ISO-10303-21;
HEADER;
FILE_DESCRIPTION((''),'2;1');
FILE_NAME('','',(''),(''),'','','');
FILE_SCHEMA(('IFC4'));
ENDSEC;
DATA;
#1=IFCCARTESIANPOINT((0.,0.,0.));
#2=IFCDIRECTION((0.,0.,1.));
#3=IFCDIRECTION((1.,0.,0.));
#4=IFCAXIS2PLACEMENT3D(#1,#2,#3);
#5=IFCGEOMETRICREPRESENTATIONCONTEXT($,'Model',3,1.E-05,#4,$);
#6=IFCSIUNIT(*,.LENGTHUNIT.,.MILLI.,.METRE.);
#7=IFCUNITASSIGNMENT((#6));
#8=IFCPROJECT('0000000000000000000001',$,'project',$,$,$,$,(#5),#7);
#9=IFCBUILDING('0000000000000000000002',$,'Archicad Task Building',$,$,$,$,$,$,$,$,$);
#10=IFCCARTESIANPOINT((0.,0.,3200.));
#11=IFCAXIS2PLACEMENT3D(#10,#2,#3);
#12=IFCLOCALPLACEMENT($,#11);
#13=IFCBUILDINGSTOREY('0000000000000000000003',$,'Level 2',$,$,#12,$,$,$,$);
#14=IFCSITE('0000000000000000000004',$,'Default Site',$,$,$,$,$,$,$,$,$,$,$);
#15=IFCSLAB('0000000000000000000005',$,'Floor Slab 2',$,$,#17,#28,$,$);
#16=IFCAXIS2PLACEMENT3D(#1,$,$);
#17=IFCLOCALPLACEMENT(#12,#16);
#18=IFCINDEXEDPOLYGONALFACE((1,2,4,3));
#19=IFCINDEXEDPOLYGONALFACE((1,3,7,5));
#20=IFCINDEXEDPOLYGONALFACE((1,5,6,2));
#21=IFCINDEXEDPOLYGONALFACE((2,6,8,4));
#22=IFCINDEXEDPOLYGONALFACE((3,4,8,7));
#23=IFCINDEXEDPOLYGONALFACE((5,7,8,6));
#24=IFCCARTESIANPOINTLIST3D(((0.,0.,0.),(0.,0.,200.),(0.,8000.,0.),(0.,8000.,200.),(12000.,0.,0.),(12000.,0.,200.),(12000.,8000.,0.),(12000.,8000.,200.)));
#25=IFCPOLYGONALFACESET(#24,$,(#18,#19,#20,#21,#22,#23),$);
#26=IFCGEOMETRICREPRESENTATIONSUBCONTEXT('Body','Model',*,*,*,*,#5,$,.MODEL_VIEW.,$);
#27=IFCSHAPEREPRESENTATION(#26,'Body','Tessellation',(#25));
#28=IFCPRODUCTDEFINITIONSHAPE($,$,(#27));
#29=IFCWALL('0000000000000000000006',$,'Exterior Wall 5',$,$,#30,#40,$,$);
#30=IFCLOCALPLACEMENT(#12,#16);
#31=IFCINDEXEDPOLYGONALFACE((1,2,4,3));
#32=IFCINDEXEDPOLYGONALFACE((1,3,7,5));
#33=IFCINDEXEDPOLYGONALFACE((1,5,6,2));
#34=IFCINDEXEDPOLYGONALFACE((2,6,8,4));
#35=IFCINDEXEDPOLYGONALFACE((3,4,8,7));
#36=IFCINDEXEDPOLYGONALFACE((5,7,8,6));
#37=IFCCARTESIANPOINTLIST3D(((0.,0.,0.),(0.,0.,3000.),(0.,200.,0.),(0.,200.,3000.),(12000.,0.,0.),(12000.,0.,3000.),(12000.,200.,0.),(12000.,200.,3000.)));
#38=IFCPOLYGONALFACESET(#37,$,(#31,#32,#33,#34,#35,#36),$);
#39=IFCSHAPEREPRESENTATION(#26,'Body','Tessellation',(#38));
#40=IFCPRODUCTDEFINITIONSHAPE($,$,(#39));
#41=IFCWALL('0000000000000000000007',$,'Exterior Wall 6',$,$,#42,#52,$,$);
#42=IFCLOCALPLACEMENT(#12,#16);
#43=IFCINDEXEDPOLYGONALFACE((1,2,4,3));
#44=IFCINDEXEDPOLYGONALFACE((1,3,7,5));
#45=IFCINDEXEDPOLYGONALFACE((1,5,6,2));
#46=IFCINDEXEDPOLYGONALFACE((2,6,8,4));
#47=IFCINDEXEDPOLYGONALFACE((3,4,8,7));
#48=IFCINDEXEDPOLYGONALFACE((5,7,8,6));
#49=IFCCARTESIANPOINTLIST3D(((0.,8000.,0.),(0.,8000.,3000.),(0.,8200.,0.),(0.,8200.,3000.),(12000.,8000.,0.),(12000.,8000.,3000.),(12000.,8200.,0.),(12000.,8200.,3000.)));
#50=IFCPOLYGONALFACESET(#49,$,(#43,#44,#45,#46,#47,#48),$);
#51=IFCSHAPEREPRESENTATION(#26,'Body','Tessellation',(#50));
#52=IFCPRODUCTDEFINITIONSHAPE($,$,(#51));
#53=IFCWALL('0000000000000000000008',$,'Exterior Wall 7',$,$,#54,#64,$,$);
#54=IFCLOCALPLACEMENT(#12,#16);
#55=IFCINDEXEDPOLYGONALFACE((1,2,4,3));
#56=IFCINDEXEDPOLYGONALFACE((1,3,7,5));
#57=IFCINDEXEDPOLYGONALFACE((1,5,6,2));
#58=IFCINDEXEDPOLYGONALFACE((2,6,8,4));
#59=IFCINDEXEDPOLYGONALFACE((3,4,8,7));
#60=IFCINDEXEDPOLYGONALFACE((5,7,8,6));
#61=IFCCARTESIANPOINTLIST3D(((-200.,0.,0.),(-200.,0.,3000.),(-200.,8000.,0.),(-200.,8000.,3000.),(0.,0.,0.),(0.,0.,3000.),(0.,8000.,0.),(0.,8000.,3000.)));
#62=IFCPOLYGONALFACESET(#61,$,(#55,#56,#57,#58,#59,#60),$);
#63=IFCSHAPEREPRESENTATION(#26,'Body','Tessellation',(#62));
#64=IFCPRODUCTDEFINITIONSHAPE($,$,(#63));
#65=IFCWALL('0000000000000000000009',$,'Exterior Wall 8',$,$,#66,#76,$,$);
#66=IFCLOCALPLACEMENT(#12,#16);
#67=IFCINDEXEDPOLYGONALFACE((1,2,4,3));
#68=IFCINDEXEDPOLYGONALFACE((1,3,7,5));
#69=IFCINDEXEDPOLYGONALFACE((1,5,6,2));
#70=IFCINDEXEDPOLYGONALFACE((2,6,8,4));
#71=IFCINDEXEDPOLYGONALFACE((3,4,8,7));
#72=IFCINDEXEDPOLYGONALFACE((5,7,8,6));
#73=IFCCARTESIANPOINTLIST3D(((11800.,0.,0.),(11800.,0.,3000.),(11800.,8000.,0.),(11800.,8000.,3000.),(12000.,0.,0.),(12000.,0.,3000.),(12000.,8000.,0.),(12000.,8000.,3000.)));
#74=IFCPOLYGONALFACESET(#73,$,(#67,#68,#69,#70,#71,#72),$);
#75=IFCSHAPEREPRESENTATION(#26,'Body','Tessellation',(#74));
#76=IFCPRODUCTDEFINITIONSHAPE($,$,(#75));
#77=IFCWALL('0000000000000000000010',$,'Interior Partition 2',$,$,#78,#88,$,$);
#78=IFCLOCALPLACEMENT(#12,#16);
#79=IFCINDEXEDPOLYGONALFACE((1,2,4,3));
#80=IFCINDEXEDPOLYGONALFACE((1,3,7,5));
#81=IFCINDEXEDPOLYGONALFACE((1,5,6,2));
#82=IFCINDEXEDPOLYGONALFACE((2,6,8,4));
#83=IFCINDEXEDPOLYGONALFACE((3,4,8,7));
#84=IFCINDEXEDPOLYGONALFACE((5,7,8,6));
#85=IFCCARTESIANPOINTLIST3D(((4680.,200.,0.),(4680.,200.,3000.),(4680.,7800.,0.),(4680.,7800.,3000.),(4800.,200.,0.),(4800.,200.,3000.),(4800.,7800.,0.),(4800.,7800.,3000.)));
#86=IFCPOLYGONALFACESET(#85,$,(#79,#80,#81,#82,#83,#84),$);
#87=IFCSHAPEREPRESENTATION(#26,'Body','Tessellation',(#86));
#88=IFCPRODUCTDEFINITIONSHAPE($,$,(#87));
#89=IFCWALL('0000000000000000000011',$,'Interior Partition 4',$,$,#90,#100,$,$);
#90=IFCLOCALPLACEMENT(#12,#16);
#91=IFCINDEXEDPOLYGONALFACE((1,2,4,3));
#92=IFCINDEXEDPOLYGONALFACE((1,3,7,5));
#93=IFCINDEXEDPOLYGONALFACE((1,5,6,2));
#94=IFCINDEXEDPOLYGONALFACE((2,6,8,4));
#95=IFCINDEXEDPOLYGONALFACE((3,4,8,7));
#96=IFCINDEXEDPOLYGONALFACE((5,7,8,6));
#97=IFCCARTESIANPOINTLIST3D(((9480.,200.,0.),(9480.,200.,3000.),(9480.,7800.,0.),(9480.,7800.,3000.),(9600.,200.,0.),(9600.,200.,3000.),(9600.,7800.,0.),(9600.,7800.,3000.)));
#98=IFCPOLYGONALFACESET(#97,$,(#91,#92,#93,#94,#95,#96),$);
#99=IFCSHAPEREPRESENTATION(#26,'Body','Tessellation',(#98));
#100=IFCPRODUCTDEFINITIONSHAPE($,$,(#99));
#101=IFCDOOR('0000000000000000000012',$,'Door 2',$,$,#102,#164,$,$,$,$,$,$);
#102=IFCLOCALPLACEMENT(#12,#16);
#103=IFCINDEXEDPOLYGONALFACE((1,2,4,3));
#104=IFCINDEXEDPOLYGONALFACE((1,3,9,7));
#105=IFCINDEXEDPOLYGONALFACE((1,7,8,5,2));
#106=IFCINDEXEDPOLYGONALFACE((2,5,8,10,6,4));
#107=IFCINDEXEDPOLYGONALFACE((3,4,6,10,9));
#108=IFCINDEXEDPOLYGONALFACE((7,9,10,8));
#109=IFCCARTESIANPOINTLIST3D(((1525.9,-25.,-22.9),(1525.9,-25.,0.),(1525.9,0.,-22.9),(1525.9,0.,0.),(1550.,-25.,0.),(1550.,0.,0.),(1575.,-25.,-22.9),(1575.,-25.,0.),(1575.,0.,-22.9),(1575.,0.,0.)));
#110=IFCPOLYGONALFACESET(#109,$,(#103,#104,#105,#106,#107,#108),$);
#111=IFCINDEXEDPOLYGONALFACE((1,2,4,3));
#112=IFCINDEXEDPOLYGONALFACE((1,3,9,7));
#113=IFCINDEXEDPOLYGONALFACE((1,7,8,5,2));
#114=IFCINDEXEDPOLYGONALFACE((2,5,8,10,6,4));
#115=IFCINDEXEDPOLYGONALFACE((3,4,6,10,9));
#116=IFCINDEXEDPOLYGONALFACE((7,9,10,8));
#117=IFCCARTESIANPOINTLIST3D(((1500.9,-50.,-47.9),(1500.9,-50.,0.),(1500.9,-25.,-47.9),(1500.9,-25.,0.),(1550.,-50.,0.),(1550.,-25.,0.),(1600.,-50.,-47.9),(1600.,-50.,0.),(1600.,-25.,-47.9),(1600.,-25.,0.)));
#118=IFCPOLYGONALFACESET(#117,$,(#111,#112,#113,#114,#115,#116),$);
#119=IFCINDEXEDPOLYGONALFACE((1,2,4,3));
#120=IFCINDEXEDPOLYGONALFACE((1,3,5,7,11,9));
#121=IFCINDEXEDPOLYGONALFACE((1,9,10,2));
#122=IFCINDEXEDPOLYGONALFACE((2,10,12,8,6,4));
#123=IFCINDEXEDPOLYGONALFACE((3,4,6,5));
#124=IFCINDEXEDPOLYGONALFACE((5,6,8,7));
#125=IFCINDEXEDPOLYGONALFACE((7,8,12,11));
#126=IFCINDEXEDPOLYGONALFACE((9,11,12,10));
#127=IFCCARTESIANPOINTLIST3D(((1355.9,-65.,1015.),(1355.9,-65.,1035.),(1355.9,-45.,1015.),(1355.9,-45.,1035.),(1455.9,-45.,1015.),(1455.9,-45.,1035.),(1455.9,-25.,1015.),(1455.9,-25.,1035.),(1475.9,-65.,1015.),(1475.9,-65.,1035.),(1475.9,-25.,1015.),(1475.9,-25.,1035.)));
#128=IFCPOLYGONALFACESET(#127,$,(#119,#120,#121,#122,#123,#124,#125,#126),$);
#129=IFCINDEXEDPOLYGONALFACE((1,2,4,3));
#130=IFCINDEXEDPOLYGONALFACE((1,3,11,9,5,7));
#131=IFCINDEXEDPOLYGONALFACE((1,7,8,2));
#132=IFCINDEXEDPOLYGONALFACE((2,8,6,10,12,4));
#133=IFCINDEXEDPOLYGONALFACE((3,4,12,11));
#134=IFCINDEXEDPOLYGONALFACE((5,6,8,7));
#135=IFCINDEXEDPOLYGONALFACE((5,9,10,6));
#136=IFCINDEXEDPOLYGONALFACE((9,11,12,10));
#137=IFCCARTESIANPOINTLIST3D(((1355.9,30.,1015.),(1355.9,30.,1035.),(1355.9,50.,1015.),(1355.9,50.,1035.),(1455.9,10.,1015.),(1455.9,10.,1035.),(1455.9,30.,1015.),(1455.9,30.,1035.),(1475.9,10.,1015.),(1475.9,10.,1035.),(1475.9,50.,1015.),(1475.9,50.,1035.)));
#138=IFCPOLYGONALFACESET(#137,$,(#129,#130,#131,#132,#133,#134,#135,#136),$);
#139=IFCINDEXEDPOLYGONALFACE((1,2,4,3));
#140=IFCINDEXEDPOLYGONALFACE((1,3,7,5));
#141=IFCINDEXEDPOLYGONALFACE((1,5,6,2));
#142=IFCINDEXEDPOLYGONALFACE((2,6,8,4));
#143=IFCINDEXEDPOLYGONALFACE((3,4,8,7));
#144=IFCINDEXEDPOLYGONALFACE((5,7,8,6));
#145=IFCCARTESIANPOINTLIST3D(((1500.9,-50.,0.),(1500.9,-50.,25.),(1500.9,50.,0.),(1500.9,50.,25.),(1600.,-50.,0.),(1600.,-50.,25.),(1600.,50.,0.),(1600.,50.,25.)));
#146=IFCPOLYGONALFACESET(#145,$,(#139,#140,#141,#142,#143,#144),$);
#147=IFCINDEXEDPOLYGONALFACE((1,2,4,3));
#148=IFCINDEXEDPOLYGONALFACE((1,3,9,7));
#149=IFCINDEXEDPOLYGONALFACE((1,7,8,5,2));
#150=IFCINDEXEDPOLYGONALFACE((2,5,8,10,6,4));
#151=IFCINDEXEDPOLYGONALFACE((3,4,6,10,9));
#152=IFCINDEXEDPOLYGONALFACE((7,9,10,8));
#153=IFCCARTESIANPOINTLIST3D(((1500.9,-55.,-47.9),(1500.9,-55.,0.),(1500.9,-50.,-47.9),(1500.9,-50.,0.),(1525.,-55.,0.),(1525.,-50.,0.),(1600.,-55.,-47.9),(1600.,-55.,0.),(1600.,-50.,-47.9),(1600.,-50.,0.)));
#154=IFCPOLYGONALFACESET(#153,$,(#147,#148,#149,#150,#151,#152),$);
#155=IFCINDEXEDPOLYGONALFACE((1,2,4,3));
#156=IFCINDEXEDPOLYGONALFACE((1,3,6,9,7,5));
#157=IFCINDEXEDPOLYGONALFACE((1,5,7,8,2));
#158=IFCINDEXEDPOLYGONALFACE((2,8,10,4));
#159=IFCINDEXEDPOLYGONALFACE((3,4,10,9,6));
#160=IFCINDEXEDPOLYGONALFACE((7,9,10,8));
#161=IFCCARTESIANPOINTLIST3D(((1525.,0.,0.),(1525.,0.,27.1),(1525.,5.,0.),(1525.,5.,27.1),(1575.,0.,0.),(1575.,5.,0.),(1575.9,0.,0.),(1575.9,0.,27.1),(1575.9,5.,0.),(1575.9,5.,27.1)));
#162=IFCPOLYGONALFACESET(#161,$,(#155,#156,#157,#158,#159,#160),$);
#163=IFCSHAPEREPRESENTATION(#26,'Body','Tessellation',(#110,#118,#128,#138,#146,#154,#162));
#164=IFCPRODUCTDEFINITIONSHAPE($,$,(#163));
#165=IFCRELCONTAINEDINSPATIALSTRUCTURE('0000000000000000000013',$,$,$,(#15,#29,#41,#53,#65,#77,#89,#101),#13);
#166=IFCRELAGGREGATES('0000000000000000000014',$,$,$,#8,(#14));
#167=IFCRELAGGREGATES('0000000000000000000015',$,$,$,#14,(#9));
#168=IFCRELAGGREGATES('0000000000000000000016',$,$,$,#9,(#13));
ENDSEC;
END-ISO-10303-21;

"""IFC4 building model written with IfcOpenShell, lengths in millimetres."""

from ifc_helpers import new_model, si_unit, frame, origin_with_axes, place, context, subcontext, project, spatial, line, indexed_curve, outline, extrude, element, save


model = new_model("IFC4")

# Units and contexts
model_context = context("Model", 3, precision=1e-05, world=origin_with_axes())
body_context = subcontext(model_context, "Body", "Model", "MODEL_VIEW")
ifc_project = project(units=[si_unit("LENGTHUNIT", "METRE", prefix="MILLI")], contexts=[model_context])

# Site, building, storey
site = spatial("IfcSite", under=ifc_project, Name="Default Site")
building = spatial("IfcBuilding", under=site, Name="Archicad Task Building")
storey_placement = place(None, frame((0.0, 0.0, 3200.0), z_axis=(0.0, 0.0, 1.0), x_axis=(1.0, 0.0, 0.0)))
storey = spatial("IfcBuildingStorey", under=building, at=storey_placement, Name="Level 2")

# Slab
slab_placement = place(storey_placement, origin_with_axes())
element("IfcSlab", 1, at=slab_placement, inside=storey, Name="Floor Slab 2", context=body_context, shape_type="SweptSolid", body=[
    extrude(outline(indexed_curve([(0.0, 0.0), (12000.0, 0.0), (12000.0, 8000.0), (0.0, 8000.0), (0.0, 0.0)])), None, (0.0, 0.0, 1.0), 200.0),
])

# Walls
for number, where, z_axis, x_axis, name in (
    (2, (0.0, 0.0, 0.0), (0.0, 0.0, 1.0), (1.0, 0.0, 0.0), "Exterior Wall 5"),
    (3, (0.0, 8000.0, 0.0), (0.0, 0.0, 1.0), (1.0, 0.0, 0.0), "Exterior Wall 6"),
):
    element("IfcWall", number, at=place(storey_placement, frame(where, z_axis=z_axis, x_axis=x_axis)), inside=storey, Name=name, context=body_context, shape_type="SweptSolid", body=[
        extrude(outline(indexed_curve([(0.0, 0.0), (0.0, 200.0), (12000.0, 200.0), (12000.0, 0.0), (0.0, 0.0)], self_intersect=False)), origin_with_axes(), (0.0, 0.0, 1.0), 3000.0),
    ])
for number, where, z_axis, x_axis, name in (
    (4, (0.0, 0.0, 0.0), (0.0, 0.0, 1.0), (0.0, 1.0, 0.0), "Exterior Wall 7"),
    (5, (12000.0, 0.0, 0.0), (0.0, 0.0, 1.0), (0.0, 1.0, 0.0), "Exterior Wall 8"),
):
    element("IfcWall", number, at=place(storey_placement, frame(where, z_axis=z_axis, x_axis=x_axis)), inside=storey, Name=name, context=body_context, shape_type="SweptSolid", body=[
        extrude(outline(indexed_curve([(0.0, 0.0), (0.0, 200.0), (8000.0, 200.0), (8000.0, 0.0), (0.0, 0.0)], self_intersect=False)), origin_with_axes(), (0.0, 0.0, 1.0), 3000.0),
    ])
for number, where, z_axis, x_axis, name in (
    (6, (4800.0, 200.0, 0.0), (0.0, 0.0, 1.0), (0.0, 1.0, 0.0), "Interior Partition 2"),
    (7, (9600.0, 200.0, 0.0), (0.0, 0.0, 1.0), (0.0, 1.0, 0.0), "Interior Partition 4"),
):
    element("IfcWall", number, at=place(storey_placement, frame(where, z_axis=z_axis, x_axis=x_axis)), inside=storey, Name=name, context=body_context, shape_type="SweptSolid", body=[
        extrude(outline(indexed_curve([(0.0, 0.0), (0.0, 120.0), (7600.0, 120.0), (7600.0, 0.0), (0.0, 0.0)], self_intersect=False)), origin_with_axes(), (0.0, 0.0, 1.0), 3000.0),
    ])

# Door
door_1_placement = place(storey_placement, frame((1550.0, -50.0, 0.0), z_axis=(0.0, 0.0, 1.0), x_axis=(1.0, 0.0, 0.0)))
element("IfcDoor", 8, at=door_1_placement, inside=storey, Name="Door 2", context=body_context, shape_type="SweptSolid", body=[
    extrude(outline(indexed_curve([(0.0, 0.0), (0.0, 2.1), (0.9, 2.1), (0.9, 0.0), (-24.1, 0.0), (-24.1, -22.9), (25.0, -22.9), (25.0, 0.0)], segments=[line(1, 2, 3, 4, 5, 6, 7, 8, 1)])), frame((0.0, 25.0, 0.0), z_axis=(0.0, -1.0, 0.0), x_axis=(1.0, 0.0, 0.0)), (0.0, 0.0, -1.0), 25.0),
    extrude(outline(indexed_curve([(0.0, 0.0), (0.0, 2.1), (0.9, 2.1), (0.9, 0.0), (-49.1, 0.0), (-49.1, -47.9), (50.0, -47.9), (50.0, 0.0)], segments=[line(1, 2, 3, 4, 5, 6, 7, 8, 1)])), frame((0.0, 0.0, 0.0), z_axis=(0.0, -1.0, 0.0), x_axis=(1.0, 0.0, 0.0)), (0.0, 0.0, -1.0), 25.0),
    extrude(outline(indexed_curve([(0.0, 0.0), (-49.1, 0.0), (-49.1, 35.0), (0.0, 35.0)], segments=[line(1, 2, 3, 4, 1)])), frame((25.0, 25.0, 25.0), z_axis=(0.0, 0.0, 1.0), x_axis=(1.0, 0.0, 0.0)), (0.0, 0.0, 1.0), -47.9),
    extrude(outline(indexed_curve([(0.0, 0.0), (0.0, -40.0), (-120.0, -40.0), (-120.0, -20.0), (-20.0, -20.0), (-20.0, 0.0)], segments=[line(1, 2, 3, 4, 5, 6, 1)])), frame((-74.1, 25.0, 1015.0), z_axis=(0.0, 0.0, 1.0), x_axis=(1.0, 0.0, 0.0)), (0.0, 0.0, 1.0), 20.0),
    extrude(outline(indexed_curve([(0.0, 0.0), (0.0, 40.0), (-120.0, 40.0), (-120.0, 20.0), (-20.0, 20.0), (-20.0, 0.0)], segments=[line(1, 2, 3, 4, 5, 6, 1)])), frame((-74.1, 60.0, 1015.0), z_axis=(0.0, 0.0, 1.0), x_axis=(1.0, 0.0, 0.0)), (0.0, 0.0, 1.0), 20.0),
    extrude(outline(indexed_curve([(0.0, 0.0), (-99.1, 0.0), (-99.1, 100.0), (0.0, 100.0)], segments=[line(1, 2, 3, 4, 1)])), frame((50.0, 0.0, 0.0), z_axis=(0.0, 0.0, 1.0), x_axis=(1.0, 0.0, 0.0)), (0.0, 0.0, 1.0), 25.0),
    extrude(outline(indexed_curve([(0.0, 0.0), (0.0, 27.1), (50.9, 27.1), (50.9, 0.0), (-24.1, 0.0), (-24.1, -47.9), (75.0, -47.9), (75.0, 0.0)], segments=[line(1, 2, 3, 4, 5, 6, 7, 8, 1)])), frame((-25.0, -5.0, 0.0), z_axis=(0.0, -1.0, 0.0), x_axis=(1.0, 0.0, 0.0)), (0.0, 0.0, -1.0), 5.0),
    extrude(outline(indexed_curve([(0.0, 0.0), (0.0, 27.1), (50.9, 27.1), (50.9, 0.0), (0.9, 0.0), (0.9, -22.9), (50.0, -22.9), (50.0, 0.0)], segments=[line(1, 2, 3, 4, 5, 6, 7, 8, 1)])), frame((-25.0, 50.0, 0.0), z_axis=(0.0, -1.0, 0.0), x_axis=(1.0, 0.0, 0.0)), (0.0, 0.0, -1.0), 5.0),
])

save(model, "model.ifc")
